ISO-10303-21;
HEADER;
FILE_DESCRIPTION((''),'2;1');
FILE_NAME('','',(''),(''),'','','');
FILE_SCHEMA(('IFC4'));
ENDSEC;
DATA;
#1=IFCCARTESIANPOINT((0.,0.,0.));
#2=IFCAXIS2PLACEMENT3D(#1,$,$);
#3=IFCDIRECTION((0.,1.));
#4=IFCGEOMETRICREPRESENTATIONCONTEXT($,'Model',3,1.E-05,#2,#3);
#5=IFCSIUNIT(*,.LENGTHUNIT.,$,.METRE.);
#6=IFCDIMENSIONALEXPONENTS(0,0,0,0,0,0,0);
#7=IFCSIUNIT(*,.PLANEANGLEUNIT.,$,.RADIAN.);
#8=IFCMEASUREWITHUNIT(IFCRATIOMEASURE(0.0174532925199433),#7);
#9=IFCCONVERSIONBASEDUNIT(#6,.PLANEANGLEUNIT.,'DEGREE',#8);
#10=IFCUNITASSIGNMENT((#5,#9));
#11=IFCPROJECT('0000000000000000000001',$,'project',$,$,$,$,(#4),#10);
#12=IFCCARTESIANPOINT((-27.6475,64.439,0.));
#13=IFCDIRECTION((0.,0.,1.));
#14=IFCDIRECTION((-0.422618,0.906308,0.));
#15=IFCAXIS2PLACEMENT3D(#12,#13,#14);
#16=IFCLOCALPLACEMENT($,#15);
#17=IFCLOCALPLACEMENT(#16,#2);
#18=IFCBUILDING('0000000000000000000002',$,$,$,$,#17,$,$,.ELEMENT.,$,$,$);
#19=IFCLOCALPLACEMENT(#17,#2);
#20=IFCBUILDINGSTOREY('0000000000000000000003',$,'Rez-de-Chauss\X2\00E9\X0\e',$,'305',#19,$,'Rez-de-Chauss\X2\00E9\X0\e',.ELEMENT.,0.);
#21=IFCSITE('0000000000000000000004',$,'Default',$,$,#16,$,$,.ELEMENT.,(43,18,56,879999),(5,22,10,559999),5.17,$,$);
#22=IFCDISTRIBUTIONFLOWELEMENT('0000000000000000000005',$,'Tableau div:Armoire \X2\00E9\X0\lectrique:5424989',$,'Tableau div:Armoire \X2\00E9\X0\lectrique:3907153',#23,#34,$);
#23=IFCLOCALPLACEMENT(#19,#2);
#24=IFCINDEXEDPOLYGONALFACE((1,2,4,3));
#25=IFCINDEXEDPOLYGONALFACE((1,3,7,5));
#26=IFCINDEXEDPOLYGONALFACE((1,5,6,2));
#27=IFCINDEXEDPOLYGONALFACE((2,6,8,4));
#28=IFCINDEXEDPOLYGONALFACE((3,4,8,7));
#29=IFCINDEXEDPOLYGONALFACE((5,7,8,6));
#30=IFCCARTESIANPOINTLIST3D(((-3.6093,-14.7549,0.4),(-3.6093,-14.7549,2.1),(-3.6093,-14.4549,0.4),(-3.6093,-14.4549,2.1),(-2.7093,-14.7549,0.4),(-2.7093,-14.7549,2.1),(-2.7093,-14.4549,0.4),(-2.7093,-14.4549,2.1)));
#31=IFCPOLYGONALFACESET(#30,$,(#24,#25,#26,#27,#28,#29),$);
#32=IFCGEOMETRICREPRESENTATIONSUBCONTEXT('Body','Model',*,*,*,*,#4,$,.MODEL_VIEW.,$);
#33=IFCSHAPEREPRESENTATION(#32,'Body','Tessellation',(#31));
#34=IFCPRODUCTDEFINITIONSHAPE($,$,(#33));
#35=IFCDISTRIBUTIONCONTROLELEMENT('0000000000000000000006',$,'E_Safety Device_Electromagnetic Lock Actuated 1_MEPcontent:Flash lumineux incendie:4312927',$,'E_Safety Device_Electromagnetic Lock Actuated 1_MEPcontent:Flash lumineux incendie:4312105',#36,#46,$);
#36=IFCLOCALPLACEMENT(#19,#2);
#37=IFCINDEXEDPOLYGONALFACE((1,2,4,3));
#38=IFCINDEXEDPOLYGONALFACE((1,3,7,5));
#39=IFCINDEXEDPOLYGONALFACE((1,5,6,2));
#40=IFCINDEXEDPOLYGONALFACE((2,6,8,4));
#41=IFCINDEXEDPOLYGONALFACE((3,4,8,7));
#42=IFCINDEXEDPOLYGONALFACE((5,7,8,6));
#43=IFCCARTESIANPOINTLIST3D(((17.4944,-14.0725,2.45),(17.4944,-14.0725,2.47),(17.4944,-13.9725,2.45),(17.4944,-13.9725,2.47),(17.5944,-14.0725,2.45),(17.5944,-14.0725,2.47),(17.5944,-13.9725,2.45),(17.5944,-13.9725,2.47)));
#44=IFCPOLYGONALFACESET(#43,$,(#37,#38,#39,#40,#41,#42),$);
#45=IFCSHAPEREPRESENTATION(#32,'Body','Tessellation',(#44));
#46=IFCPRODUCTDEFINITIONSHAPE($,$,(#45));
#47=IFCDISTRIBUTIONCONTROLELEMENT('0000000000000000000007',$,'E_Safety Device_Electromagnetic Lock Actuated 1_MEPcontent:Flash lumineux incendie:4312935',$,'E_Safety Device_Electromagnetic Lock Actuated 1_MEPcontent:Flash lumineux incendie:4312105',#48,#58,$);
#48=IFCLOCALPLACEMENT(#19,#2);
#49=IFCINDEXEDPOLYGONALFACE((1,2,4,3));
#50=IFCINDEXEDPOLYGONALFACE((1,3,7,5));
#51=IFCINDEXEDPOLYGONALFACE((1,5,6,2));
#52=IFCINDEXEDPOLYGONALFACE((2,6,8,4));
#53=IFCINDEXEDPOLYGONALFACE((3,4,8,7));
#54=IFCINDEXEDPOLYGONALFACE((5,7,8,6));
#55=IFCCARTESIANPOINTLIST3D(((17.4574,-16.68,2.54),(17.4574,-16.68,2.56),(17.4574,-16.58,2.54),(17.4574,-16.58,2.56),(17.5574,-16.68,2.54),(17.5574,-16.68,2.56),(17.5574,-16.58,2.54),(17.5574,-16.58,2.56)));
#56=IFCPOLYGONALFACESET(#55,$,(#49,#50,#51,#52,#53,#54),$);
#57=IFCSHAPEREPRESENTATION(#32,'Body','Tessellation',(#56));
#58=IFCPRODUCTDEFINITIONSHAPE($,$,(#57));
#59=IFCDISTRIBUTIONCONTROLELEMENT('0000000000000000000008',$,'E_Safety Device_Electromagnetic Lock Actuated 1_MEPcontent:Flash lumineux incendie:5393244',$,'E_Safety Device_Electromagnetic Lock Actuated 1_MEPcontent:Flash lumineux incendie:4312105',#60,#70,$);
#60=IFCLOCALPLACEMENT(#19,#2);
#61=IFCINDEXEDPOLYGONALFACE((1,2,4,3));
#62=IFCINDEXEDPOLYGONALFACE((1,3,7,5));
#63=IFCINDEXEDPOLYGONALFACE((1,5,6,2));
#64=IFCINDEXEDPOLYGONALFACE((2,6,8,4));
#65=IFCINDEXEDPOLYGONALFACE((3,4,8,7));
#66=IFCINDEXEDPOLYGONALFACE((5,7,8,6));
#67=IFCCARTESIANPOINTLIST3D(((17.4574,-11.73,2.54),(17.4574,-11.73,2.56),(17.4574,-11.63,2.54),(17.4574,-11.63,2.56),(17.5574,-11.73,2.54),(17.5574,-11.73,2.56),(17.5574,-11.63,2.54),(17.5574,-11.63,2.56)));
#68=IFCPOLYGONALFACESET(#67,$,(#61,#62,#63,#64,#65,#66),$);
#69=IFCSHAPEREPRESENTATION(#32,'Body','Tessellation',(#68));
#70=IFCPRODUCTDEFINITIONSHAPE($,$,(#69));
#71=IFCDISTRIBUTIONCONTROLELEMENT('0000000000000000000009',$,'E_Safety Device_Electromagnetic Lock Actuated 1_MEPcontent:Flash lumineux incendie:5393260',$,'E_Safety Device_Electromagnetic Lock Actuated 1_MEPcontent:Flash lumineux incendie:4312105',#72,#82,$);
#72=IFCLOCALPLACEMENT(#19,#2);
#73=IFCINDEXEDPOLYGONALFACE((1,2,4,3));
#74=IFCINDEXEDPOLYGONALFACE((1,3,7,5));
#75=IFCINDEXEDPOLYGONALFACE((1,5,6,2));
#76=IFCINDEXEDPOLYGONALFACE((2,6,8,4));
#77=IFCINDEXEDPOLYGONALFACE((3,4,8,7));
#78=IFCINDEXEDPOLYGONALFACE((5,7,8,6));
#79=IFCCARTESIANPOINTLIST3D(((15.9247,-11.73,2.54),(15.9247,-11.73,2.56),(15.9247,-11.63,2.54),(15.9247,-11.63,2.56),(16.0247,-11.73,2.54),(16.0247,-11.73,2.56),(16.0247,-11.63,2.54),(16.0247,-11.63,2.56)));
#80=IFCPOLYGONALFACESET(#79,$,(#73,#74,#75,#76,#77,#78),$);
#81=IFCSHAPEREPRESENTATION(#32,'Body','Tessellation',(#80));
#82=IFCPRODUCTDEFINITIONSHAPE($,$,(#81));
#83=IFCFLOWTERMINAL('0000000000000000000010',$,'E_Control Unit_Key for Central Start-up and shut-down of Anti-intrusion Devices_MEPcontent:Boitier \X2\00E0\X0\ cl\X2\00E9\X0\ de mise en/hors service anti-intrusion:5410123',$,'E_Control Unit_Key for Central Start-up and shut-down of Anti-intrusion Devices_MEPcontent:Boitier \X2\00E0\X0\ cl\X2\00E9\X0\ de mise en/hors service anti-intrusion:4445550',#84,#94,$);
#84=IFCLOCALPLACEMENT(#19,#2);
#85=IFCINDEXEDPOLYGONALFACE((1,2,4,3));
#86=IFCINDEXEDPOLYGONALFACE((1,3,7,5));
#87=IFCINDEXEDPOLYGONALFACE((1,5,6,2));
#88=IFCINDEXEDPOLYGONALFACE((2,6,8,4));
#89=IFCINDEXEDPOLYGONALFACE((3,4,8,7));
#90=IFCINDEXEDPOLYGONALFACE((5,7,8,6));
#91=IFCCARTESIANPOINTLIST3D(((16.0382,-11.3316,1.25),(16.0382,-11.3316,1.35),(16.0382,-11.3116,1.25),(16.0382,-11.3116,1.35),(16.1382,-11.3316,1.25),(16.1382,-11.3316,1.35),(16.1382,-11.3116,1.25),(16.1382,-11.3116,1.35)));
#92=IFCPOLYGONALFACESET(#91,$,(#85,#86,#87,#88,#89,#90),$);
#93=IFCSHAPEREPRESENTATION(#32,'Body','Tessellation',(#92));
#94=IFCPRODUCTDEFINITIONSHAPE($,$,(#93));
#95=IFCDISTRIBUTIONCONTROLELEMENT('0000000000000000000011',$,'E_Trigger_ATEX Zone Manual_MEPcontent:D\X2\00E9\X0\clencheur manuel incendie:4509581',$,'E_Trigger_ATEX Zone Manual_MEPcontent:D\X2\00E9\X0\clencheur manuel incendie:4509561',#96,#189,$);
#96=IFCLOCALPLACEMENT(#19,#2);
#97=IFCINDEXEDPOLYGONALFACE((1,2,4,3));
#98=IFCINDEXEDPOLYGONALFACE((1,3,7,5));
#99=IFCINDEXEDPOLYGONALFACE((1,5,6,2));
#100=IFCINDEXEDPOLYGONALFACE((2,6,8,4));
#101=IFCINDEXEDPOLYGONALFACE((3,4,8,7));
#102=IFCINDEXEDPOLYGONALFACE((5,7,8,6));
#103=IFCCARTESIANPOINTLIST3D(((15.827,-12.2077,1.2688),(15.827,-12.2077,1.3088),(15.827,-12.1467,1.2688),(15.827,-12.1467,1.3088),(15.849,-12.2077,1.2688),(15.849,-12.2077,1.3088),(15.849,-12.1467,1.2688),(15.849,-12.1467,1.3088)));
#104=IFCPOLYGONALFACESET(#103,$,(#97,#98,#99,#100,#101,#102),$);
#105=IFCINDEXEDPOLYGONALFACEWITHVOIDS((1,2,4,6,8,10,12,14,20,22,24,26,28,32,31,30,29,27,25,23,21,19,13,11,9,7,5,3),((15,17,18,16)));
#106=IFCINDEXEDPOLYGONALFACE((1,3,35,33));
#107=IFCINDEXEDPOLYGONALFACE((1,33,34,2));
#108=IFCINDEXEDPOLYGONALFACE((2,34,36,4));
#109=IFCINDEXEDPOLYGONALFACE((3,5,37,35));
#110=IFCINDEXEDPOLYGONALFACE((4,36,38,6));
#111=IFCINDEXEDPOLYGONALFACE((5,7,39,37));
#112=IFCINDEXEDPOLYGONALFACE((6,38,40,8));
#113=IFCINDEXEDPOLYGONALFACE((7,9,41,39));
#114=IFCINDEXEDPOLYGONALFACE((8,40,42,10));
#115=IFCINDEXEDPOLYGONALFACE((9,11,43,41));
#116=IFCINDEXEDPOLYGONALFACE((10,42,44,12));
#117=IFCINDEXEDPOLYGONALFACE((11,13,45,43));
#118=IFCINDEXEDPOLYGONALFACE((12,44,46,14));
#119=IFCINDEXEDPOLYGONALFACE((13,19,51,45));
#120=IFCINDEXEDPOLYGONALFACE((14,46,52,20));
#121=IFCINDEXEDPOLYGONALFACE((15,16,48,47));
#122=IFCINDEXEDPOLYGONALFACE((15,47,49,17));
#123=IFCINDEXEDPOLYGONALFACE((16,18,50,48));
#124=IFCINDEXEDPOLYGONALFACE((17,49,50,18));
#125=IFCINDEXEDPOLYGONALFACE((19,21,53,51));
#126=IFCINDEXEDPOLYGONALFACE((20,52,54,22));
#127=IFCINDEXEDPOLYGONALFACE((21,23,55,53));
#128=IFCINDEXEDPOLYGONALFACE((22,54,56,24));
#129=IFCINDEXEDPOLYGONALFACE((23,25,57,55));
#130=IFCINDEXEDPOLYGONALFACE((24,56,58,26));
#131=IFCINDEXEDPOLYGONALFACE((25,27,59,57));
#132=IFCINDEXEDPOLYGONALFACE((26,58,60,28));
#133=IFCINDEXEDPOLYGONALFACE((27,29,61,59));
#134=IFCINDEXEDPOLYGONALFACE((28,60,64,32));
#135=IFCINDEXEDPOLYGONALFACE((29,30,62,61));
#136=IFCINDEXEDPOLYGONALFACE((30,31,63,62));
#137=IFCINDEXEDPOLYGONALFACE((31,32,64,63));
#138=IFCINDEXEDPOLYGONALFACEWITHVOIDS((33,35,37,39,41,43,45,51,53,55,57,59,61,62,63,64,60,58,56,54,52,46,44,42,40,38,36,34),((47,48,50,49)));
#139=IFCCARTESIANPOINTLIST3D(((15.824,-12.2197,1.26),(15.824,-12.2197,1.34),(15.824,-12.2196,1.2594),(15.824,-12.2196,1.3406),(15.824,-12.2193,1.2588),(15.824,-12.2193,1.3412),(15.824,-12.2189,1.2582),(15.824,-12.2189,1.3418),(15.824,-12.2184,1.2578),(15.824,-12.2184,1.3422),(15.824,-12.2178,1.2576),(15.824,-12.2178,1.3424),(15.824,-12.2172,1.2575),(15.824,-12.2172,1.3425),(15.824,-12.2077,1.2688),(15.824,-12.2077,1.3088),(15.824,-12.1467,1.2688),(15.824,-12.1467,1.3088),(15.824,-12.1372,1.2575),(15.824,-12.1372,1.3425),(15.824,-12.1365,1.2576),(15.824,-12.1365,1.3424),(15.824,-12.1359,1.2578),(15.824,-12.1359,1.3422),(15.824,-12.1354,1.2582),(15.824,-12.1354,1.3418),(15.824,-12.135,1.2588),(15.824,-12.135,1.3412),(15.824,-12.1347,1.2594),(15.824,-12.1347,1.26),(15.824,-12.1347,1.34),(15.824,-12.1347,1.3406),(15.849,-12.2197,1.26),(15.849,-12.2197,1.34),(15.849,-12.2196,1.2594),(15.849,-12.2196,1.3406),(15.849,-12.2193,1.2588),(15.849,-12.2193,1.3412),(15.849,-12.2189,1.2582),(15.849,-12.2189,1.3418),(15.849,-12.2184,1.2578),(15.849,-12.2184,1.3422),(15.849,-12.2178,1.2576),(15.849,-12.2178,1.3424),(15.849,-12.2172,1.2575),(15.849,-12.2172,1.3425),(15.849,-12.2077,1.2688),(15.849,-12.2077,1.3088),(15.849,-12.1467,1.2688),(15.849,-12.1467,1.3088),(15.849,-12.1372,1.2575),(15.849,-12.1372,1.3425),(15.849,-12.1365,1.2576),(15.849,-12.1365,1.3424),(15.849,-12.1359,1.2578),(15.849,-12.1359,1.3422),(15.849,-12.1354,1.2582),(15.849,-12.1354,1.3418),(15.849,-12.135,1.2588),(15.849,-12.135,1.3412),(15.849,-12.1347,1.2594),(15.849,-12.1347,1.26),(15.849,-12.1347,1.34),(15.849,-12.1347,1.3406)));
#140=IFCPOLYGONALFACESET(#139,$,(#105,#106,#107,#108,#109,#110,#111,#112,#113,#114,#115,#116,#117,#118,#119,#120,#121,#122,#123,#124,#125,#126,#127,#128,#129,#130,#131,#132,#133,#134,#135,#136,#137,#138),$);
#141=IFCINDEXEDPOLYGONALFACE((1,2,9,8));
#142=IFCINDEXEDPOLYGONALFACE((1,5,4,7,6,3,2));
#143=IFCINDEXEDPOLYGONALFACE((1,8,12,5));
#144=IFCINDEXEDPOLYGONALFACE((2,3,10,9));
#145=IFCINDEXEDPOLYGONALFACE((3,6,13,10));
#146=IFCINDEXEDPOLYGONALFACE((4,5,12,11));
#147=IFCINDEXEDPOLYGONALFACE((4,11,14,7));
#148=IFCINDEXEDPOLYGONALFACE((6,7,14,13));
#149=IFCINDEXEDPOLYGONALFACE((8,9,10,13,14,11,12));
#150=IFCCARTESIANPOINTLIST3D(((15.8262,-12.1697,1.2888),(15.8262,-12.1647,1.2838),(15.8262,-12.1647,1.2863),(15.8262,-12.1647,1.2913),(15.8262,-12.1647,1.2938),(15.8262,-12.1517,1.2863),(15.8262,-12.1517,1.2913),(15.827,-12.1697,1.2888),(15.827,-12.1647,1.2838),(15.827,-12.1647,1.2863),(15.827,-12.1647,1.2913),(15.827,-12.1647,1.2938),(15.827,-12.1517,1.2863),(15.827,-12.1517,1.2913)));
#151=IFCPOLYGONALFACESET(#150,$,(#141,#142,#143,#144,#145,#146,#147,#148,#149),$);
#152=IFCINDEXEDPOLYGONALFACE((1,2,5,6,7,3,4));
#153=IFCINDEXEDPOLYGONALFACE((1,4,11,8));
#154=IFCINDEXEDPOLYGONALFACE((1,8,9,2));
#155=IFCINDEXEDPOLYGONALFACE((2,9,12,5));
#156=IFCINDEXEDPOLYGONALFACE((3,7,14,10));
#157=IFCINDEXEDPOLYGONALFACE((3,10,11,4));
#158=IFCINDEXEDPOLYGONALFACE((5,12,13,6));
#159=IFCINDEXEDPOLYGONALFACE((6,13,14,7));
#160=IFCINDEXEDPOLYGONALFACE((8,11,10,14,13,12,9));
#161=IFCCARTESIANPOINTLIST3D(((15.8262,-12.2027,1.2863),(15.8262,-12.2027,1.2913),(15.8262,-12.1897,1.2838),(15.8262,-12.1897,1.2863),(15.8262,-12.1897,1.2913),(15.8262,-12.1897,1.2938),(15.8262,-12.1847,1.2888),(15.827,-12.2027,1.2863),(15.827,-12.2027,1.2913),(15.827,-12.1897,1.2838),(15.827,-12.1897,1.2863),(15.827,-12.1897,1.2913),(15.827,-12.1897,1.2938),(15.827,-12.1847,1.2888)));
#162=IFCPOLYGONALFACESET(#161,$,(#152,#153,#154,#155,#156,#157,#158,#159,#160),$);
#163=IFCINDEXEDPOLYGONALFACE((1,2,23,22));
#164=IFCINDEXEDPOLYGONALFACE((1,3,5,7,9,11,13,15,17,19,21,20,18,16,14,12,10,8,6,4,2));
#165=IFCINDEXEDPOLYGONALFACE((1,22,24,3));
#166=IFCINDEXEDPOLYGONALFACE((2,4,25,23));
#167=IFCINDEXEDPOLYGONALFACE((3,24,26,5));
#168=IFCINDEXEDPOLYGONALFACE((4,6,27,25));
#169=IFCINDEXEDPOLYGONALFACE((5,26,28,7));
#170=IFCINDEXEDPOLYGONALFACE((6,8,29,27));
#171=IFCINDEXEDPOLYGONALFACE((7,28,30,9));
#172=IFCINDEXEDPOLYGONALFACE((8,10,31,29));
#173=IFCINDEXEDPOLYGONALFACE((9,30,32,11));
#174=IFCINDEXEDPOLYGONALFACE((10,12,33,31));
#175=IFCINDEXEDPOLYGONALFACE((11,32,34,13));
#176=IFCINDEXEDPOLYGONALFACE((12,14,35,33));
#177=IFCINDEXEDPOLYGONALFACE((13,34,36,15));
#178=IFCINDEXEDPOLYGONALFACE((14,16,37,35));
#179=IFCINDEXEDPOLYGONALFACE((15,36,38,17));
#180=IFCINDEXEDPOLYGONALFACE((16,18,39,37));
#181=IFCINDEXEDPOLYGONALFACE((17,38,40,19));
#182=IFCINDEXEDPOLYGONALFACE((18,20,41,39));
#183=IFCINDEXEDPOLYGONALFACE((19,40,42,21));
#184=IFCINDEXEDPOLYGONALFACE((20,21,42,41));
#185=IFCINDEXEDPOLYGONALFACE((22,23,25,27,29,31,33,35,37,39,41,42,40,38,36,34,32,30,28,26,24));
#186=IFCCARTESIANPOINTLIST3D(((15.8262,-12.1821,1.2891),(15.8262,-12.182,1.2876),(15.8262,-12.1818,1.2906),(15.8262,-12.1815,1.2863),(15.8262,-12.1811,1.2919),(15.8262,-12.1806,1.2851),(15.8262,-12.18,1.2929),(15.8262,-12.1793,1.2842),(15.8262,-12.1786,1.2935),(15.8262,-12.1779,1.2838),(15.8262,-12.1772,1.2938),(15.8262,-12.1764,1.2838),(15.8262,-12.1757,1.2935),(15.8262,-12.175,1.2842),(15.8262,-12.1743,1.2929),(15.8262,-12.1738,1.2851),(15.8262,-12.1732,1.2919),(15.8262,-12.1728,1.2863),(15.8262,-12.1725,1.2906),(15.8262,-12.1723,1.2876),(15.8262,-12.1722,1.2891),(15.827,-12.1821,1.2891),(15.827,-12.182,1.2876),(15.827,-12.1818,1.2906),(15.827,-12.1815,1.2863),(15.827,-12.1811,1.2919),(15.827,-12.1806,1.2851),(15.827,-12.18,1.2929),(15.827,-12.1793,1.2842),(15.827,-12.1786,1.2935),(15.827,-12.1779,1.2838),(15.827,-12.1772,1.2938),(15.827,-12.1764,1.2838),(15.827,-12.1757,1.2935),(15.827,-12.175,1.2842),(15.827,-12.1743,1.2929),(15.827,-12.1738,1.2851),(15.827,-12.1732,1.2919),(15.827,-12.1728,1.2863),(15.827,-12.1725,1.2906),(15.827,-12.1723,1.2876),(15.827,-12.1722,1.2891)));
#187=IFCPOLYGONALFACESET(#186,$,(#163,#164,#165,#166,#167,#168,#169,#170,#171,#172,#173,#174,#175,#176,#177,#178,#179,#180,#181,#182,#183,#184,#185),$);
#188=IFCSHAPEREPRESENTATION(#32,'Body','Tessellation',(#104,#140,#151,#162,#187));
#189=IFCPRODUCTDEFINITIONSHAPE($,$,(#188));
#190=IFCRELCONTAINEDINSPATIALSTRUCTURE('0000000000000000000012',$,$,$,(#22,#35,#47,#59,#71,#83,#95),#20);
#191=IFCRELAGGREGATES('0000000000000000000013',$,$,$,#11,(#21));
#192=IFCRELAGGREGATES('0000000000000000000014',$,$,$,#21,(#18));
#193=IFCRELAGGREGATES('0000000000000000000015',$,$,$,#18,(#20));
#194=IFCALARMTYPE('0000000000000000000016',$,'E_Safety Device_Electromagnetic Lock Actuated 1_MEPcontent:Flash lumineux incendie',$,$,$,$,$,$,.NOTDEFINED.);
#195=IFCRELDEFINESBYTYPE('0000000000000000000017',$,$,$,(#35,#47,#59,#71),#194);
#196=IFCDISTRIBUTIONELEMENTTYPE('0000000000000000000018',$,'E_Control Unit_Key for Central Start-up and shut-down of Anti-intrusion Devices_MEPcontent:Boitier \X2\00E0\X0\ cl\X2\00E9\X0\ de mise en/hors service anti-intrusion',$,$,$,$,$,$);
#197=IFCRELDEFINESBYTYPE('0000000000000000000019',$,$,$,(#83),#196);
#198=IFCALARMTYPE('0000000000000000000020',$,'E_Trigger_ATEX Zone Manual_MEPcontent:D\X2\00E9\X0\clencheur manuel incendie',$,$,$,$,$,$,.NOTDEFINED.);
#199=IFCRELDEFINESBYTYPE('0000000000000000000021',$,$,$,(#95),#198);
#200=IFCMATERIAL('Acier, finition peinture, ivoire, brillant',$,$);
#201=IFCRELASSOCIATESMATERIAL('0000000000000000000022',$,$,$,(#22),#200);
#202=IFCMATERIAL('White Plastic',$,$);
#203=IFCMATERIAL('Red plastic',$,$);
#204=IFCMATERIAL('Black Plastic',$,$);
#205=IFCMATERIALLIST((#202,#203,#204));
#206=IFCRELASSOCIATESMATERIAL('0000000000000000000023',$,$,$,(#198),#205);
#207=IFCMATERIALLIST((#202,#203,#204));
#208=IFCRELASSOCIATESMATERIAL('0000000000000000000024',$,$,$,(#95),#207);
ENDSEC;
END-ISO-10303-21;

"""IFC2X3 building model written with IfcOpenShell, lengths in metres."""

from ifc_helpers import new_model, entity, si_unit, converted_unit, direction, frame, frame_2d, origin, origin_2d_with_axis, place, context, subcontext, project, spatial, polyline, circle_curve, parameter, trimmed, segment, composite_curve, rectangle, circle, outline, extrude, source, transform, mapped, material, material_list, type_object, type_shapes, element, save


model = new_model("IFC2X3")

# Units and contexts
model_context = context("Model", 3, precision=1e-05, world=origin(), true_north=direction((0.0, 1.0)))
body_context = subcontext(model_context, "Body", "Model", "MODEL_VIEW")
ifc_project = project(units=[si_unit("LENGTHUNIT", "METRE"), converted_unit("PLANEANGLEUNIT", "DEGREE", entity("IfcRatioMeasure", 0.0174532925199433), si_unit("PLANEANGLEUNIT", "RADIAN"), dimensions=[0, 0, 0, 0, 0, 0, 0])], contexts=[model_context])

# Site, building, storey
site_placement = place(None, frame((-27.6475, 64.439, 0.0), z_axis=(0.0, 0.0, 1.0), x_axis=(-0.422618, 0.906308, 0.0)))
site = spatial("IfcSite", under=ifc_project, at=site_placement, Name="Default", CompositionType="ELEMENT", RefLatitude=(43, 18, 56, 879999), RefLongitude=(5, 22, 10, 559999), RefElevation=5.17)
building_placement = place(site_placement, origin())
building = spatial("IfcBuilding", under=site, at=building_placement, CompositionType="ELEMENT")
storey_placement = place(building_placement, origin())
storey = spatial("IfcBuildingStorey", under=building, at=storey_placement, Name="Rez-de-Chaussée", ObjectType="305", LongName="Rez-de-Chaussée", CompositionType="ELEMENT", Elevation=0.0)

# Distribution flow element
ifc_material_1 = material(Name="Acier, finition peinture, ivoire, brillant")
shared_shape_1 = source(origin(), body_context, "Body", "SweptSolid", [
    extrude(rectangle(XDim=0.9, YDim=0.3, at=origin_2d_with_axis()), frame((0.0, -0.45, 0.0), z_axis=(0.0, 0.0, 1.0), x_axis=(0.0, 1.0, 0.0)), (0.0, 0.0, 1.0), 1.7),
])
distribution_flow_element_placement = place(storey_placement, frame((-2.7093, -14.6049, 0.4), z_axis=(0.0, 0.0, 1.0), x_axis=(0.0, -1.0, 0.0)))
element("IfcDistributionFlowElement", 1, at=distribution_flow_element_placement, inside=storey, material=ifc_material_1, Name="Tableau div:Armoire électrique:5424989", ObjectType="Tableau div:Armoire électrique:3907153", context=body_context, shape_type="MappedRepresentation", body=[
    mapped(shared_shape_1, transform((0.0, 0.0, 0.0), scale=1.0)),
])

# Distribution control elements
alarm_type_1 = type_object("IfcAlarmType", Name="E_Safety Device_Electromagnetic Lock Actuated 1_MEPcontent:Flash lumineux incendie", PredefinedType="NOTDEFINED")
shared_shape_2 = source(origin(), body_context, "Body", "SweptSolid", [
    extrude(rectangle(XDim=0.1, YDim=0.1, at=origin_2d_with_axis()), frame((0.0, 0.0, 0.0), z_axis=(0.0, 0.0, 1.0), x_axis=(0.0, -1.0, 0.0)), (0.0, 0.0, 1.0), 0.02),
])
type_shapes(alarm_type_1, [shared_shape_2])
for number, where, z_axis, x_axis, name in (
    (2, (17.5444, -14.0225, 2.45), (0.0, 0.0, 1.0), (0.0, -1.0, 0.0), "E_Safety Device_Electromagnetic Lock Actuated 1_MEPcontent:Flash lumineux incendie:4312927"),
    (3, (17.5074, -16.63, 2.54), (0.0, 0.0, 1.0), (0.0, 1.0, 0.0), "E_Safety Device_Electromagnetic Lock Actuated 1_MEPcontent:Flash lumineux incendie:4312935"),
    (4, (17.5074, -11.68, 2.54), (0.0, 0.0, 1.0), (0.0, 1.0, 0.0), "E_Safety Device_Electromagnetic Lock Actuated 1_MEPcontent:Flash lumineux incendie:5393244"),
    (5, (15.9747, -11.68, 2.54), (0.0, 0.0, 1.0), (0.0, 1.0, 0.0), "E_Safety Device_Electromagnetic Lock Actuated 1_MEPcontent:Flash lumineux incendie:5393260"),
):
    element("IfcDistributionControlElement", number, at=place(storey_placement, frame(where, z_axis=z_axis, x_axis=x_axis)), inside=storey, type_object=alarm_type_1, Name=name, ObjectType="E_Safety Device_Electromagnetic Lock Actuated 1_MEPcontent:Flash lumineux incendie:4312105", context=body_context, shape_type="MappedRepresentation", body=[
        mapped(shared_shape_2, transform((0.0, 0.0, 0.0), scale=1.0)),
    ])

# Flow terminal
distribution_element_type_1 = type_object("IfcDistributionElementType", Name="E_Control Unit_Key for Central Start-up and shut-down of Anti-intrusion Devices_MEPcontent:Boitier à clé de mise en/hors service anti-intrusion")
shared_shape_3 = source(origin(), body_context, "Body", "SweptSolid", [
    extrude(rectangle(XDim=0.02, YDim=0.1, at=frame_2d((0.0, 0.0), x_axis=(1.0, 0.0))), frame((0.0, -0.01, -0.05), z_axis=(0.0, 0.0, 1.0), x_axis=(0.0, 1.0, 0.0)), (0.0, 0.0, 1.0), 0.1),
])
type_shapes(distribution_element_type_1, [shared_shape_3])
flow_terminal_1_placement = place(storey_placement, frame((16.0882, -11.3316, 1.3), z_axis=(0.0, 0.0, 1.0), x_axis=(-1.0, 0.0, 0.0)))
element("IfcFlowTerminal", 6, at=flow_terminal_1_placement, inside=storey, type_object=distribution_element_type_1, Name="E_Control Unit_Key for Central Start-up and shut-down of Anti-intrusion Devices_MEPcontent:Boitier à clé de mise en/hors service anti-intrusion:5410123", ObjectType="E_Control Unit_Key for Central Start-up and shut-down of Anti-intrusion Devices_MEPcontent:Boitier à clé de mise en/hors service anti-intrusion:4445550", context=body_context, shape_type="MappedRepresentation", body=[
    mapped(shared_shape_3, transform((0.0, 0.0, 0.0), scale=1.0)),
])

# Distribution control element
ifc_material_2 = material(Name="White Plastic")
ifc_material_3 = material(Name="Red plastic")
ifc_material_4 = material(Name="Black Plastic")
ifc_material_list_1 = material_list([ifc_material_2, ifc_material_3, ifc_material_4])
ifc_material_list_2 = material_list([ifc_material_2, ifc_material_3, ifc_material_4])
alarm_type_2 = type_object("IfcAlarmType", Name="E_Trigger_ATEX Zone Manual_MEPcontent:Déclencheur manuel incendie", PredefinedType="NOTDEFINED", material=ifc_material_list_2)
shared_shape_4 = source(origin(), body_context, "Body", "SweptSolid", [
    extrude(rectangle(XDim=0.022, YDim=0.061, at=frame_2d((0.0, 0.0), x_axis=(1.0, 0.0))), frame((0.0, 0.011, -0.0312), z_axis=(0.0, 0.0, 1.0), x_axis=(0.0, -1.0, 0.0)), (0.0, 0.0, 1.0), 0.04),
    extrude(outline(composite_curve([segment(polyline([(-0.04, -0.0425), (0.04, -0.0425)]), True, "CONTINUOUS"), segment(trimmed(circle_curve(frame_2d((0.04, -0.04), x_axis=(-1.0, 0.0)), 0.0025), [parameter(90.0)], [parameter(180.0)], True, "PARAMETER"), True, "CONTINUOUS"), segment(polyline([(0.0425, -0.04), (0.0425, 0.04)]), True, "CONTINUOUS"), segment(trimmed(circle_curve(frame_2d((0.04, 0.04), x_axis=(-1.0, 0.0)), 0.0025), [parameter(180.0)], [parameter(270.0)], True, "PARAMETER"), True, "CONTINUOUS"), segment(polyline([(0.04, 0.0425), (-0.04, 0.0425)]), True, "CONTINUOUS"), segment(trimmed(circle_curve(frame_2d((-0.04, 0.04), x_axis=(-1.0, 0.0)), 0.0025), [parameter(270.0)], [parameter(0.0)], True, "PARAMETER"), True, "CONTINUOUS"), segment(polyline([(-0.0425, 0.04), (-0.0425, -0.04)]), True, "CONTINUOUS"), segment(trimmed(circle_curve(frame_2d((-0.04, -0.04), x_axis=(-1.0, 0.0)), 0.0025), [parameter(360.0)], [parameter(90.0)], True, "PARAMETER"), True, "CONTINUOUS")], self_intersect=False), holes=[polyline([(-0.0305, -0.0088), (-0.0305, 0.0312), (0.0305, 0.0312), (0.0305, -0.0088), (-0.0305, -0.0088)])]), frame((0.0, 0.0, 0.0), z_axis=(0.0, 1.0, 0.0), x_axis=(1.0, 0.0, 0.0)), (0.0, 0.0, 1.0), 0.025),
    extrude(outline(polyline([(-0.01, 0.0025), (-0.01, -0.0025), (0.003, -0.0025), (0.003, -0.005), (0.008, 0.0), (0.003, 0.005), (0.003, 0.0025), (-0.01, 0.0025)])), frame((0.0155, 0.022, -0.0112), z_axis=(0.0, -1.0, 0.0), x_axis=(-1.0, 0.0, 0.0)), (0.0, 0.0, -1.0), 0.0008),
    extrude(outline(polyline([(-0.0014, -0.0057), (0.0057, -0.0057), (0.0057, 0.0014), (0.0039, -0.0004), (-0.0053, 0.0088), (-0.0088, 0.0053), (0.0004, -0.0039), (-0.0014, -0.0057)])), frame((-0.0155, 0.022, -0.0112), z_axis=(0.0, 1.0, 0.0), x_axis=(0.707107, 0.0, -0.707107)), (0.0, 0.0, 1.0), 0.0008),
    extrude(circle(Radius=0.005, at=frame_2d((0.0, 0.0), x_axis=(1.0, 0.0))), frame((0.0, 0.022, -0.0112), z_axis=(0.0, 1.0, 0.0), x_axis=(0.0, 0.0, 1.0)), (0.0, 0.0, 1.0), 0.0008),
])
type_shapes(alarm_type_2, [shared_shape_4])
distribution_control_element_placement = place(storey_placement, frame((15.849, -12.1772, 1.3), z_axis=(0.0, 0.0, 1.0), x_axis=(0.0, 1.0, 0.0)))
element("IfcDistributionControlElement", 7, at=distribution_control_element_placement, inside=storey, type_object=alarm_type_2, material=ifc_material_list_1, Name="E_Trigger_ATEX Zone Manual_MEPcontent:Déclencheur manuel incendie:4509581", ObjectType="E_Trigger_ATEX Zone Manual_MEPcontent:Déclencheur manuel incendie:4509561", context=body_context, shape_type="MappedRepresentation", body=[
    mapped(shared_shape_4, transform((0.0, 0.0, 0.0), scale=1.0)),
])

save(model, "model.ifc")
